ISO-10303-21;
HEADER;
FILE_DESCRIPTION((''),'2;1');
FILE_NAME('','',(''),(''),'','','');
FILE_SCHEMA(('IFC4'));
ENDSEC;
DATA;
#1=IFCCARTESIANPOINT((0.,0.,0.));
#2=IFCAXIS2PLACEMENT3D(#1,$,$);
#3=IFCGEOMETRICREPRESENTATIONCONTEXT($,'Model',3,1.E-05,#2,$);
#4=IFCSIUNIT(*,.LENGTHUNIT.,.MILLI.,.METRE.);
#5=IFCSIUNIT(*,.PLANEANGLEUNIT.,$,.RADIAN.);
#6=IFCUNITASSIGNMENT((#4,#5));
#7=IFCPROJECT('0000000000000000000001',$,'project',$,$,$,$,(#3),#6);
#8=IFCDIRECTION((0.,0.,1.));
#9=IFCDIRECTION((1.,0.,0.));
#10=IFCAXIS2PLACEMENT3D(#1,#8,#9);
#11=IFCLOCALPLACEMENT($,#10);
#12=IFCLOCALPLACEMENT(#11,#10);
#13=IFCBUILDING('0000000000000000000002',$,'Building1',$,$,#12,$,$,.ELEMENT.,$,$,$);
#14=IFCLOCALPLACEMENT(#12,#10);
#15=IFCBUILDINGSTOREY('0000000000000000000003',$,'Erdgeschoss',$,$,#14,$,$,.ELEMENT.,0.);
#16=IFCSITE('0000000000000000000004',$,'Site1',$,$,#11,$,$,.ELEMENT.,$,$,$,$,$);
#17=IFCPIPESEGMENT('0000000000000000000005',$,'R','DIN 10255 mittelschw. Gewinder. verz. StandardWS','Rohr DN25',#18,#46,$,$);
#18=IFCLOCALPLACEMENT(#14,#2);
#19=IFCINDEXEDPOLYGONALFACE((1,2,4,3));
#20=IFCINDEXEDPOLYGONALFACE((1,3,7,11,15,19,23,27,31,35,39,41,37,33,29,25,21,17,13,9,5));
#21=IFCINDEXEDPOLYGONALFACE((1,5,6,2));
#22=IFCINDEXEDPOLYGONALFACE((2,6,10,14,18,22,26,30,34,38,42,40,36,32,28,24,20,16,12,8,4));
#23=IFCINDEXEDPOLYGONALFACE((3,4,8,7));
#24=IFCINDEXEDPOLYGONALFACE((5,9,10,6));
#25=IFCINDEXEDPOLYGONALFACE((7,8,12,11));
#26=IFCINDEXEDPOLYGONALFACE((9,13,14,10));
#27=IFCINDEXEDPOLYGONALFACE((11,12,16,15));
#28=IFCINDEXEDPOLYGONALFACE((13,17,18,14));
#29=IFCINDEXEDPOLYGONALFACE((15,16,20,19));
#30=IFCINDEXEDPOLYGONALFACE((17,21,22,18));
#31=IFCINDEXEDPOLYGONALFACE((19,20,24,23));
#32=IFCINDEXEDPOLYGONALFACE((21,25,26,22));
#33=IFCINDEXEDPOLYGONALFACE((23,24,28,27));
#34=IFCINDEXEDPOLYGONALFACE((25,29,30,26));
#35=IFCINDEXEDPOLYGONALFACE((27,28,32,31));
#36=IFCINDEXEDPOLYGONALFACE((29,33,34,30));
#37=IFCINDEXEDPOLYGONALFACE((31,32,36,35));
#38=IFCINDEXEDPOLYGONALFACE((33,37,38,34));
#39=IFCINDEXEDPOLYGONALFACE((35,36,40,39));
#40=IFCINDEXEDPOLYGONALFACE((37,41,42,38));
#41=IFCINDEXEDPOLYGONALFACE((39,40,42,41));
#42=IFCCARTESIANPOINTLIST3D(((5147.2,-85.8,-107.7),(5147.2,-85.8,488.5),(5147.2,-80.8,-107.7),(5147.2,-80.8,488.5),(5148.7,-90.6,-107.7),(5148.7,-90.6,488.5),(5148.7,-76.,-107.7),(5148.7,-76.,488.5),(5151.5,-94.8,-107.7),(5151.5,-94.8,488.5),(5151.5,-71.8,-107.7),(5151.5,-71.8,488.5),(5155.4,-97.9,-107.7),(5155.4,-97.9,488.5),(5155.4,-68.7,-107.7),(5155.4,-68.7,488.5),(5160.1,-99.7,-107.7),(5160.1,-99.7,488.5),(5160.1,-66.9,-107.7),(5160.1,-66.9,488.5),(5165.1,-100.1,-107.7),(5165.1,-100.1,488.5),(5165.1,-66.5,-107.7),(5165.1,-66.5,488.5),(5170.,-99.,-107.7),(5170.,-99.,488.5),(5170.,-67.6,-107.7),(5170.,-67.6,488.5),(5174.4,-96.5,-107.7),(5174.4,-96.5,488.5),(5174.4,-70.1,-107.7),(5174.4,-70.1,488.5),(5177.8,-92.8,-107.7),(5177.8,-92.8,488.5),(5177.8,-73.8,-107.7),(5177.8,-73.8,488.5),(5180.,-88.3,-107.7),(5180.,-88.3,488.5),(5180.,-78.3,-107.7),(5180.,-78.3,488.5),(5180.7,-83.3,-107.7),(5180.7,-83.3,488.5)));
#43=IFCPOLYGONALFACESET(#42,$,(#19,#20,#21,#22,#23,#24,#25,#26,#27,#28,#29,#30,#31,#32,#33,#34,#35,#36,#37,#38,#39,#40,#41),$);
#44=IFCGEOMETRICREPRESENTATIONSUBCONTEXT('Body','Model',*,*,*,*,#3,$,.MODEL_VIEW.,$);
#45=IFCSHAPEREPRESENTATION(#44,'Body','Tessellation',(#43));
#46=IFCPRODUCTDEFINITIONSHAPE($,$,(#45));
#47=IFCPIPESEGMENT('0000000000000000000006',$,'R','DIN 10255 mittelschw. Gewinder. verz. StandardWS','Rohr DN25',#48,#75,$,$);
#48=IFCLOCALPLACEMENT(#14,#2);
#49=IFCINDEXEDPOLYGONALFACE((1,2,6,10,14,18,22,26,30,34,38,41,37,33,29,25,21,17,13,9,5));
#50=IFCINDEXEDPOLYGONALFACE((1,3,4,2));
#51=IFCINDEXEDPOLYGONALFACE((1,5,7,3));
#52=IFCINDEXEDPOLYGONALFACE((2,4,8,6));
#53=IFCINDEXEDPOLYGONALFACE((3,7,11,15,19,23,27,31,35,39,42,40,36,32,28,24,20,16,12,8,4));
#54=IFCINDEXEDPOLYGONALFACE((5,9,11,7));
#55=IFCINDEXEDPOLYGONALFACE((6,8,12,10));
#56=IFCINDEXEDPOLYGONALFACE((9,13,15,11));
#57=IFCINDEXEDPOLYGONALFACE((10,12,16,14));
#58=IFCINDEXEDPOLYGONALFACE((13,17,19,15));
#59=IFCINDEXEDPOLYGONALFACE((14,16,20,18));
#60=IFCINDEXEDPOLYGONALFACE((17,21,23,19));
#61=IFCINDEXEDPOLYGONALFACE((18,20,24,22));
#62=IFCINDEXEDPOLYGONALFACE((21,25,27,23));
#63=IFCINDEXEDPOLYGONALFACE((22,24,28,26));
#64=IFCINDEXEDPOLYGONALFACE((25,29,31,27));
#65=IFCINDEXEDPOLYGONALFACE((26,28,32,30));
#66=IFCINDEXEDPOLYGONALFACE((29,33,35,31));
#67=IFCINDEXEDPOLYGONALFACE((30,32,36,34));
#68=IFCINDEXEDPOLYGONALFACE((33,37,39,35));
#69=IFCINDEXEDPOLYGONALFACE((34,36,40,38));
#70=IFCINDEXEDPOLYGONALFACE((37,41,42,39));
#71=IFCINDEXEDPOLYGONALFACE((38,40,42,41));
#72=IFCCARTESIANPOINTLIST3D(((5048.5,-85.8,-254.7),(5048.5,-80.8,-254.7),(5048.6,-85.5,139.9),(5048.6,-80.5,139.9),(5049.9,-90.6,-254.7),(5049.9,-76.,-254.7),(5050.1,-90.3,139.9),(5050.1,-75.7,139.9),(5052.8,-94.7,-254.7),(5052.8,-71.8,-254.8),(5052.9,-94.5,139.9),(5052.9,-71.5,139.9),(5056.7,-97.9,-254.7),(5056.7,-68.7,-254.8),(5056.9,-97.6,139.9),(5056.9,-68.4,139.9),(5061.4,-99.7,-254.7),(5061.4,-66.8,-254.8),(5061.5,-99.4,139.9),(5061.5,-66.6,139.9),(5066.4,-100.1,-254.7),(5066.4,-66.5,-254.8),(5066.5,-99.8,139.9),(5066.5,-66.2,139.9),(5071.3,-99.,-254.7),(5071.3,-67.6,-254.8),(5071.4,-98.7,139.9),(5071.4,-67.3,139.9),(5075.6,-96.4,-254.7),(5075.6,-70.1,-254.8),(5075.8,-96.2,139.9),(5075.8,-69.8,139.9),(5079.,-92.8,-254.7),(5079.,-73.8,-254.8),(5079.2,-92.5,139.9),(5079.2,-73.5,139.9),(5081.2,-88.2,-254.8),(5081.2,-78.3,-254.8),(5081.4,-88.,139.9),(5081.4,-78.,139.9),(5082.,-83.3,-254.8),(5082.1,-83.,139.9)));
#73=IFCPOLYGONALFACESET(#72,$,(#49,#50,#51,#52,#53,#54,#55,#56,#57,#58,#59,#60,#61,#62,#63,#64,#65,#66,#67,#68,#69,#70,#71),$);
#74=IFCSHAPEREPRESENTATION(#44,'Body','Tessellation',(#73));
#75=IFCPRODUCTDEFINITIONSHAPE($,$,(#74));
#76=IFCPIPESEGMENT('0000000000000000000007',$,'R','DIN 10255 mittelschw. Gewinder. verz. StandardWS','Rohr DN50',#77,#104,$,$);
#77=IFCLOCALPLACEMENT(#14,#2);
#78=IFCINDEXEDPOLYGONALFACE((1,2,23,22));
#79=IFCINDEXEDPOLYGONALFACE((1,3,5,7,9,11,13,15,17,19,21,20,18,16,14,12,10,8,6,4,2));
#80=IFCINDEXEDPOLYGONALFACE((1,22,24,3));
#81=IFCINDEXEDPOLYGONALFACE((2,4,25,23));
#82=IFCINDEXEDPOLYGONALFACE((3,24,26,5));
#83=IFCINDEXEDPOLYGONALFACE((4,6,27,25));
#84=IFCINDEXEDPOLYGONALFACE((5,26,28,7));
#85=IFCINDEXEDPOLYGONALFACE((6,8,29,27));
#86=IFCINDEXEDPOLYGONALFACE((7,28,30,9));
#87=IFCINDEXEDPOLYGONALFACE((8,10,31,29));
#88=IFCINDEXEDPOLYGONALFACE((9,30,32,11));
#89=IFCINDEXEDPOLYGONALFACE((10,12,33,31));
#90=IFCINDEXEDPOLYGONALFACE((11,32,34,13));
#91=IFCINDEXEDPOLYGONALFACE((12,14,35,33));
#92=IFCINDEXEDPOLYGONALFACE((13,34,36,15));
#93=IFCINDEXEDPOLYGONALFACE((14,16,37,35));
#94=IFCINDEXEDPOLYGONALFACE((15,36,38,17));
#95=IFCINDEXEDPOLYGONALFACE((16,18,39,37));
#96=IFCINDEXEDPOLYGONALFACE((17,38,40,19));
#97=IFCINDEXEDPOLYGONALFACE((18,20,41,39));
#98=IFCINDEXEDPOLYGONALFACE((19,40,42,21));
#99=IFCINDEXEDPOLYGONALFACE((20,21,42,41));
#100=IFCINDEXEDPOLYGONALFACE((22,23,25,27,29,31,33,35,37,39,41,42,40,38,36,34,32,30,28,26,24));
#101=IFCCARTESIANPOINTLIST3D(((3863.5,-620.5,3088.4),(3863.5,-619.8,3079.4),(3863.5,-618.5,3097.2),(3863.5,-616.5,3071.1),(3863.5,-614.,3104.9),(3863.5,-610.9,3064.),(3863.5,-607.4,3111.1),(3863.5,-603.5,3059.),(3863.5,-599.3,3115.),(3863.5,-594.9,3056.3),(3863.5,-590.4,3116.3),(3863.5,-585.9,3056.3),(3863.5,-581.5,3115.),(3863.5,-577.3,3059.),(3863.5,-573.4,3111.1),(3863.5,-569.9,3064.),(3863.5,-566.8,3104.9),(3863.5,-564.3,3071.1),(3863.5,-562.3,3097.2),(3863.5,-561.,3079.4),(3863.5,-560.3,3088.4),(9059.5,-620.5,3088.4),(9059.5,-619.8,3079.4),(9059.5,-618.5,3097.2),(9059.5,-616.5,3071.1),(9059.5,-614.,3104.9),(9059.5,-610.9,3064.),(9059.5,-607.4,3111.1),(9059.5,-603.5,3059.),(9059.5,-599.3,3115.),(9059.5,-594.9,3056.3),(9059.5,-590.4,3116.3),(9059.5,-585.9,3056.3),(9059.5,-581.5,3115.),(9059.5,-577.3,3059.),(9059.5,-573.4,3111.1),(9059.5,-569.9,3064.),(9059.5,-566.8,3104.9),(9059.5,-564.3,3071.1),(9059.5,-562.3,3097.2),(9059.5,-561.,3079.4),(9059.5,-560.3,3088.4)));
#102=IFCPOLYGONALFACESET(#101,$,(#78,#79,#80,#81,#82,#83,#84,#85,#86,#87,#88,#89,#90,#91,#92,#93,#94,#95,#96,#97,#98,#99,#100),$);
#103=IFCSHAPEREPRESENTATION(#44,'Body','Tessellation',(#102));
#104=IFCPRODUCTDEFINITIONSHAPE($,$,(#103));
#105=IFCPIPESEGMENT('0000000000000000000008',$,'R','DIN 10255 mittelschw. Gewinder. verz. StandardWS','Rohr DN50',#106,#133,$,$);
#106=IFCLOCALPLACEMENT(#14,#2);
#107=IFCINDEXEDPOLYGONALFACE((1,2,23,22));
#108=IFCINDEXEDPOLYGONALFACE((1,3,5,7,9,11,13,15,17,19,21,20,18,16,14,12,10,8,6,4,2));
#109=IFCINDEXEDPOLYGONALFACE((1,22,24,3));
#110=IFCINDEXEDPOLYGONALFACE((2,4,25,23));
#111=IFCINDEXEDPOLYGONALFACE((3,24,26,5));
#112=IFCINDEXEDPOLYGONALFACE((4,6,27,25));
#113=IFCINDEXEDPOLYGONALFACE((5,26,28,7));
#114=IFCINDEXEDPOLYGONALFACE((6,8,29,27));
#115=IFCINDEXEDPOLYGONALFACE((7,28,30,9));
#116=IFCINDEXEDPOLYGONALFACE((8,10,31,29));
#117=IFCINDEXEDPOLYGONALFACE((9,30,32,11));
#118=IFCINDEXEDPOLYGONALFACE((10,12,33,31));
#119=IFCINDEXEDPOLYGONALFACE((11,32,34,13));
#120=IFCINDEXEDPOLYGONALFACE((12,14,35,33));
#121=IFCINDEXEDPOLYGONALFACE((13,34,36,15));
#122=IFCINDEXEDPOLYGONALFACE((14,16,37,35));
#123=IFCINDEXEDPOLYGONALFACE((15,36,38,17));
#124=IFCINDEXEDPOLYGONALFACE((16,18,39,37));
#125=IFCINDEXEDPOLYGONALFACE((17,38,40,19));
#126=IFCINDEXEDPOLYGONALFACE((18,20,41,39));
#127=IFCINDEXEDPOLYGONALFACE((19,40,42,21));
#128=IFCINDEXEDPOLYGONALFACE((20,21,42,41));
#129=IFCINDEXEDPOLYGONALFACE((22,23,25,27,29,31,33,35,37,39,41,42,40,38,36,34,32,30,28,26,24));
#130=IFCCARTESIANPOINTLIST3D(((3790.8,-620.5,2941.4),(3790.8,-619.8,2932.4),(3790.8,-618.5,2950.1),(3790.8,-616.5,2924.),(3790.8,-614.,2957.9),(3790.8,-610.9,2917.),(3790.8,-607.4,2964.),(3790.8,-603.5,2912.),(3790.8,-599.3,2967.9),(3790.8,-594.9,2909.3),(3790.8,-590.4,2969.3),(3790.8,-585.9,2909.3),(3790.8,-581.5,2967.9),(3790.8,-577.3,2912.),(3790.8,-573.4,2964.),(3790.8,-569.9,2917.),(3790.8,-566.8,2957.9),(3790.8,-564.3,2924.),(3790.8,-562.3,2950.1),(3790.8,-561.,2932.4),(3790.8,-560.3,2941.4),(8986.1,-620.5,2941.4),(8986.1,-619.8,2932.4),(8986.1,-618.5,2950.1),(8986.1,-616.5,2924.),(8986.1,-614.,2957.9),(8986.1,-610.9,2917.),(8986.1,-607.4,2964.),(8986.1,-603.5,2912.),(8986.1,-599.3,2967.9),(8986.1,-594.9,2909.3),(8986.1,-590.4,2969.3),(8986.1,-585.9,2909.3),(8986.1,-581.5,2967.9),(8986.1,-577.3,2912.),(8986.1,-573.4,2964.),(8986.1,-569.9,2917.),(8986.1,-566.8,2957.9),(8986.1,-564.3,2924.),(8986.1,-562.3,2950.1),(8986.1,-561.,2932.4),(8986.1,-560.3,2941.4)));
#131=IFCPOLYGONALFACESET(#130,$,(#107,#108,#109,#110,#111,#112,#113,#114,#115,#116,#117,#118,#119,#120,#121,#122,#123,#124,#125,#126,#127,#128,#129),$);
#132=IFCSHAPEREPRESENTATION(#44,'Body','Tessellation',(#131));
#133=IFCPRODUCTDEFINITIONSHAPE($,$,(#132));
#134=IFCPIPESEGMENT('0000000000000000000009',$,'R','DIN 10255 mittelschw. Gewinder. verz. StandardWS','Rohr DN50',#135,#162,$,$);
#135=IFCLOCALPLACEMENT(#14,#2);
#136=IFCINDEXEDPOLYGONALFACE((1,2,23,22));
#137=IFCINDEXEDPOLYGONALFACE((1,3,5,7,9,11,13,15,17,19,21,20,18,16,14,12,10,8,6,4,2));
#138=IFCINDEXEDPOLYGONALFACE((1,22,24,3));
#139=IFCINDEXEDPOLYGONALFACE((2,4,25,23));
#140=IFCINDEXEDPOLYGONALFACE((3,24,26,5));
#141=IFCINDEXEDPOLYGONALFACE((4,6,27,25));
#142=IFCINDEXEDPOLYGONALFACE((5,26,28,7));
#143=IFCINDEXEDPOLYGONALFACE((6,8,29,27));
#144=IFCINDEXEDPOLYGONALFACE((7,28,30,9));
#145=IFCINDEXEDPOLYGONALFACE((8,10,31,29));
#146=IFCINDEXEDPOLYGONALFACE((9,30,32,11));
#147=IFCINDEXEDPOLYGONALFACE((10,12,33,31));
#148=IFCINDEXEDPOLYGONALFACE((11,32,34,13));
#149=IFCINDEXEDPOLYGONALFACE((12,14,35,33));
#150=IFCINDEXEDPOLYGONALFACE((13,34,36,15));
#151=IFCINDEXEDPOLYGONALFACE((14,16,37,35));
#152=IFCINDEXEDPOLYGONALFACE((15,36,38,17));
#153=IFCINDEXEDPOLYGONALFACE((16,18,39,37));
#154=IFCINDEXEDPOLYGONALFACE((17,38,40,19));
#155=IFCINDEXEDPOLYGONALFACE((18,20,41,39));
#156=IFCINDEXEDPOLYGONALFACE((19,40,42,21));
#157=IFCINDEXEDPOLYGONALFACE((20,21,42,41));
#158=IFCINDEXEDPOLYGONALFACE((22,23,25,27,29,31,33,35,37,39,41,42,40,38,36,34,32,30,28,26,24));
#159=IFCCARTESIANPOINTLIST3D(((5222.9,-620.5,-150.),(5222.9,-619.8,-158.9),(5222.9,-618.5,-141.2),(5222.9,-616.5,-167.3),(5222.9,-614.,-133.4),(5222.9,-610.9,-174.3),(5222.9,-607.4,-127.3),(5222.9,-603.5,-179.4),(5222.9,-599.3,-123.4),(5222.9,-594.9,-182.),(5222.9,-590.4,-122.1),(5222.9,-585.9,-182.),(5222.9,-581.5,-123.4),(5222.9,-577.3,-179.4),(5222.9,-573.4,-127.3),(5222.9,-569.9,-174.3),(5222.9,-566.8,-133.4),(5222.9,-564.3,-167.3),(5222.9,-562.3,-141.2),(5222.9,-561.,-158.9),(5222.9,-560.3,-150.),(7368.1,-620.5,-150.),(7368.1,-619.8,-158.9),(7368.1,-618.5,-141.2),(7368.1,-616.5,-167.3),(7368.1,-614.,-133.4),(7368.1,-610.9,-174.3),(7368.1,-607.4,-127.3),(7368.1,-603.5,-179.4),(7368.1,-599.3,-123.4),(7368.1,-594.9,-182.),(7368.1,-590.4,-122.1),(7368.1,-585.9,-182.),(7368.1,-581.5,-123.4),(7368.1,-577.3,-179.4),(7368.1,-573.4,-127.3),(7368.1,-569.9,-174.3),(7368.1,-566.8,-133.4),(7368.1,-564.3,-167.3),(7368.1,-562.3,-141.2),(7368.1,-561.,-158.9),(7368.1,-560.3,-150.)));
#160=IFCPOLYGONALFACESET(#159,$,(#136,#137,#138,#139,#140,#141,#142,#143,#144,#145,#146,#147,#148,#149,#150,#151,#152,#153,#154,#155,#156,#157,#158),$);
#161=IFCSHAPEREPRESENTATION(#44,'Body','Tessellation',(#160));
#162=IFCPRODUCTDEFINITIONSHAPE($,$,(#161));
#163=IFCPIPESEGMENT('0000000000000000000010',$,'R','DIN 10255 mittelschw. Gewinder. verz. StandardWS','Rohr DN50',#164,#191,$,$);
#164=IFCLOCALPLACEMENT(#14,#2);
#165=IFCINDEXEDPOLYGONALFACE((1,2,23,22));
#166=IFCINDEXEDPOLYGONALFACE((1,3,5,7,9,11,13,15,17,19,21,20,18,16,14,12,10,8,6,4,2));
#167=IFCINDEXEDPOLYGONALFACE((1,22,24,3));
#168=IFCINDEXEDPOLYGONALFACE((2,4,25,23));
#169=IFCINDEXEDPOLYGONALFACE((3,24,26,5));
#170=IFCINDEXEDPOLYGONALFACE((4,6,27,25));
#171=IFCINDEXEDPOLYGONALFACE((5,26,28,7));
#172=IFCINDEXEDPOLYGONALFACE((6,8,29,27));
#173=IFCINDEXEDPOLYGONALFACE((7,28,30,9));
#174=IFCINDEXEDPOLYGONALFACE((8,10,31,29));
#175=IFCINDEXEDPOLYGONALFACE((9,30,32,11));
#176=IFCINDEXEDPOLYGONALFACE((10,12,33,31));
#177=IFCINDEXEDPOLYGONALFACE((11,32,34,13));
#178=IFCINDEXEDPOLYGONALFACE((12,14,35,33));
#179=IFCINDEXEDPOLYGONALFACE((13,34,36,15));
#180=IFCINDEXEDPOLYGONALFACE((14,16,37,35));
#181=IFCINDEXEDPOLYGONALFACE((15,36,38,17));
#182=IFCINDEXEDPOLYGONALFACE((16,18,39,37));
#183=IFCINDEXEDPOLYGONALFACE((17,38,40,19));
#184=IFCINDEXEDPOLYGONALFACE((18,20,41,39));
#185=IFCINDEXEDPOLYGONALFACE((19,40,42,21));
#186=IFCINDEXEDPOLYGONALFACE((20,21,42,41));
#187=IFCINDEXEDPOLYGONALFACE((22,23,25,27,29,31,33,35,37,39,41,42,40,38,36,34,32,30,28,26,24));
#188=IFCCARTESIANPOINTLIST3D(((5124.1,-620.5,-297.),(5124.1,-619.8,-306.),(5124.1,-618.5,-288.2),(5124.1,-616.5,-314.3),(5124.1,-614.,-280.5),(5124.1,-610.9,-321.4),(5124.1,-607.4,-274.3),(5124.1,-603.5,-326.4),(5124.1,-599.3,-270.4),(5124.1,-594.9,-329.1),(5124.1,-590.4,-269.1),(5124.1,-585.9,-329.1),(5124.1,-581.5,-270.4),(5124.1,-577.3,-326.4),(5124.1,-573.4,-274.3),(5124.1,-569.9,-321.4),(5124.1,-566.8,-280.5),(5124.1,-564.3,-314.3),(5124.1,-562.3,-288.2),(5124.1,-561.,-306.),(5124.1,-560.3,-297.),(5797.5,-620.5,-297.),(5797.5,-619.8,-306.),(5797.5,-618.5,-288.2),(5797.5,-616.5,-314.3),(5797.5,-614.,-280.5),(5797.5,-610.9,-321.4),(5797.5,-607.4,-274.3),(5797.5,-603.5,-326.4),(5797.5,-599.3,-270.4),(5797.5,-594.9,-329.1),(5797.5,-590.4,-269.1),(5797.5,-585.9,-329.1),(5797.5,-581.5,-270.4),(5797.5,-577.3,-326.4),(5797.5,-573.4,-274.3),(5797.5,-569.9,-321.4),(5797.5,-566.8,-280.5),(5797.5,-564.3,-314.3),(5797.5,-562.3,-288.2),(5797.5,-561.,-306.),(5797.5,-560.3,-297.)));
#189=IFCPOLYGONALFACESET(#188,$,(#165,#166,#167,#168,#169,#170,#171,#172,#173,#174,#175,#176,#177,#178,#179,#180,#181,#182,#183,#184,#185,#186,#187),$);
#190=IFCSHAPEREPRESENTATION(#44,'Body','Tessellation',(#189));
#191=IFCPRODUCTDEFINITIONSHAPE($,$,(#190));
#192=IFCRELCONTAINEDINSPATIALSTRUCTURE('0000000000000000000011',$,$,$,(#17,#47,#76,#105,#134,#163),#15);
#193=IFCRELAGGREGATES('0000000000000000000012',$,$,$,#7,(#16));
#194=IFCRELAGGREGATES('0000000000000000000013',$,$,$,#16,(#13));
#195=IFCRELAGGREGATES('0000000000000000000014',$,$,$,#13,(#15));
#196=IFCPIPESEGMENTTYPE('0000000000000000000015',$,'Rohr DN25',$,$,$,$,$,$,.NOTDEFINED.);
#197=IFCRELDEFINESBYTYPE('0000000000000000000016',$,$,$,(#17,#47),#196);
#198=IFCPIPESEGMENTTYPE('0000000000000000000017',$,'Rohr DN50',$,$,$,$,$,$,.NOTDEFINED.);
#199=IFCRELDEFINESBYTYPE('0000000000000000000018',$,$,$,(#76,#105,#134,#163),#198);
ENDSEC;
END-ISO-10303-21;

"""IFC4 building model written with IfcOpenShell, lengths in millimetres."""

from ifc_helpers import new_model, si_unit, frame, origin, origin_with_axes, origin_2d_with_axis, place, context, subcontext, project, spatial, circle, extrude, type_object, element, save


model = new_model("IFC4")

# Units and contexts
model_context = context("Model", 3, precision=1e-05, world=origin())
body_context = subcontext(model_context, "Body", "Model", "MODEL_VIEW")
ifc_project = project(units=[si_unit("LENGTHUNIT", "METRE", prefix="MILLI"), si_unit("PLANEANGLEUNIT", "RADIAN")], contexts=[model_context])

# Site, building, storey
site_placement = place(None, origin_with_axes())
site = spatial("IfcSite", under=ifc_project, at=site_placement, Name="Site1", CompositionType="ELEMENT")
building_placement = place(site_placement, origin_with_axes())
building = spatial("IfcBuilding", under=site, at=building_placement, Name="Building1", CompositionType="ELEMENT")
storey_placement = place(building_placement, origin_with_axes())
storey = spatial("IfcBuildingStorey", under=building, at=storey_placement, Name="Erdgeschoss", CompositionType="ELEMENT", Elevation=0.0)

# Pipe segments
pipe_segment_type_1 = type_object("IfcPipeSegmentType", Name="Rohr DN25", PredefinedType="NOTDEFINED")
pipe_segment_1_placement = place(storey_placement, frame((5163.9, -83.4, 190.4), z_axis=(0.0, 0.0, 1.0), x_axis=(1.0, 0.0, 0.0)))
element("IfcPipeSegment", 1, at=pipe_segment_1_placement, inside=storey, type_object=pipe_segment_type_1, Name="R", Description="DIN 10255 mittelschw. Gewinder. verz. StandardWS", ObjectType="Rohr DN25", context=body_context, shape_type="SolidModel", body=[
    extrude(circle(Radius=16.9, at=origin_2d_with_axis()), frame((0.0, 0.1, -298.1), z_axis=(0.0, 0.0, 1.0), x_axis=(1.0, 0.0, 0.0)), (0.0, 0.0, 1.0), 596.2),
])
pipe_segment_2_placement = place(storey_placement, frame((5065.2, -83.3, -57.4), z_axis=(0.0, 0.0, 1.0), x_axis=(1.0, 0.0, 0.0)))
element("IfcPipeSegment", 2, at=pipe_segment_2_placement, inside=storey, type_object=pipe_segment_type_1, Name="R", Description="DIN 10255 mittelschw. Gewinder. verz. StandardWS", ObjectType="Rohr DN25", context=body_context, shape_type="SolidModel", body=[
    extrude(circle(Radius=16.9, at=origin_2d_with_axis()), frame((-0.1, 0.0, -197.3), z_axis=(0.000425, 0.000703, 1.0), x_axis=(1.0, 0.0, 0.0)), (0.0, 0.0, 1.0), 394.7),
])
pipe_segment_type_2 = type_object("IfcPipeSegmentType", Name="Rohr DN50", PredefinedType="NOTDEFINED")
pipe_segment_3_placement = place(storey_placement, frame((6461.5, -590.3, 3086.1), z_axis=(0.0, 0.0, 1.0), x_axis=(1.0, 0.0, 0.0)))
element("IfcPipeSegment", 3, at=pipe_segment_3_placement, inside=storey, type_object=pipe_segment_type_2, Name="R", Description="DIN 10255 mittelschw. Gewinder. verz. StandardWS", ObjectType="Rohr DN50", context=body_context, shape_type="SolidModel", body=[
    extrude(circle(Radius=30.1, at=origin_2d_with_axis()), frame((-2598.0, -0.2, 0.0), z_axis=(1.0, 0.0, 0.0), x_axis=(0.0, 0.0, 1.0)), (0.0, 0.0, 1.0), 5196.0),
])
pipe_segment_4_placement = place(storey_placement, frame((6388.5, -590.3, 2939.1), z_axis=(0.0, 0.0, 1.0), x_axis=(1.0, 0.0, 0.0)))
element("IfcPipeSegment", 4, at=pipe_segment_4_placement, inside=storey, type_object=pipe_segment_type_2, Name="R", Description="DIN 10255 mittelschw. Gewinder. verz. StandardWS", ObjectType="Rohr DN50", context=body_context, shape_type="SolidModel", body=[
    extrude(circle(Radius=30.1, at=origin_2d_with_axis()), frame((-2597.7, -0.2, 0.0), z_axis=(1.0, 0.0, 0.0), x_axis=(0.0, 0.0, 1.0)), (0.0, 0.0, 1.0), 5195.4),
])
pipe_segment_5_placement = place(storey_placement, frame((6295.5, -590.3, -152.2), z_axis=(0.0, 0.0, 1.0), x_axis=(1.0, 0.0, 0.0)))
element("IfcPipeSegment", 5, at=pipe_segment_5_placement, inside=storey, type_object=pipe_segment_type_2, Name="R", Description="DIN 10255 mittelschw. Gewinder. verz. StandardWS", ObjectType="Rohr DN50", context=body_context, shape_type="SolidModel", body=[
    extrude(circle(Radius=30.1, at=origin_2d_with_axis()), frame((-1072.6, -0.2, 0.0), z_axis=(1.0, 0.0, 0.0), x_axis=(0.0, 0.0, 1.0)), (0.0, 0.0, 1.0), 2145.3),
])
pipe_segment_6_placement = place(storey_placement, frame((5460.8, -590.3, -299.2), z_axis=(0.0, 0.0, 1.0), x_axis=(1.0, 0.0, 0.0)))
element("IfcPipeSegment", 6, at=pipe_segment_6_placement, inside=storey, type_object=pipe_segment_type_2, Name="R", Description="DIN 10255 mittelschw. Gewinder. verz. StandardWS", ObjectType="Rohr DN50", context=body_context, shape_type="SolidModel", body=[
    extrude(circle(Radius=30.1, at=origin_2d_with_axis()), frame((-336.7, -0.2, 0.0), z_axis=(1.0, 0.0, 0.0), x_axis=(0.0, 0.0, 1.0)), (0.0, 0.0, 1.0), 673.4),
])

save(model, "model.ifc")
